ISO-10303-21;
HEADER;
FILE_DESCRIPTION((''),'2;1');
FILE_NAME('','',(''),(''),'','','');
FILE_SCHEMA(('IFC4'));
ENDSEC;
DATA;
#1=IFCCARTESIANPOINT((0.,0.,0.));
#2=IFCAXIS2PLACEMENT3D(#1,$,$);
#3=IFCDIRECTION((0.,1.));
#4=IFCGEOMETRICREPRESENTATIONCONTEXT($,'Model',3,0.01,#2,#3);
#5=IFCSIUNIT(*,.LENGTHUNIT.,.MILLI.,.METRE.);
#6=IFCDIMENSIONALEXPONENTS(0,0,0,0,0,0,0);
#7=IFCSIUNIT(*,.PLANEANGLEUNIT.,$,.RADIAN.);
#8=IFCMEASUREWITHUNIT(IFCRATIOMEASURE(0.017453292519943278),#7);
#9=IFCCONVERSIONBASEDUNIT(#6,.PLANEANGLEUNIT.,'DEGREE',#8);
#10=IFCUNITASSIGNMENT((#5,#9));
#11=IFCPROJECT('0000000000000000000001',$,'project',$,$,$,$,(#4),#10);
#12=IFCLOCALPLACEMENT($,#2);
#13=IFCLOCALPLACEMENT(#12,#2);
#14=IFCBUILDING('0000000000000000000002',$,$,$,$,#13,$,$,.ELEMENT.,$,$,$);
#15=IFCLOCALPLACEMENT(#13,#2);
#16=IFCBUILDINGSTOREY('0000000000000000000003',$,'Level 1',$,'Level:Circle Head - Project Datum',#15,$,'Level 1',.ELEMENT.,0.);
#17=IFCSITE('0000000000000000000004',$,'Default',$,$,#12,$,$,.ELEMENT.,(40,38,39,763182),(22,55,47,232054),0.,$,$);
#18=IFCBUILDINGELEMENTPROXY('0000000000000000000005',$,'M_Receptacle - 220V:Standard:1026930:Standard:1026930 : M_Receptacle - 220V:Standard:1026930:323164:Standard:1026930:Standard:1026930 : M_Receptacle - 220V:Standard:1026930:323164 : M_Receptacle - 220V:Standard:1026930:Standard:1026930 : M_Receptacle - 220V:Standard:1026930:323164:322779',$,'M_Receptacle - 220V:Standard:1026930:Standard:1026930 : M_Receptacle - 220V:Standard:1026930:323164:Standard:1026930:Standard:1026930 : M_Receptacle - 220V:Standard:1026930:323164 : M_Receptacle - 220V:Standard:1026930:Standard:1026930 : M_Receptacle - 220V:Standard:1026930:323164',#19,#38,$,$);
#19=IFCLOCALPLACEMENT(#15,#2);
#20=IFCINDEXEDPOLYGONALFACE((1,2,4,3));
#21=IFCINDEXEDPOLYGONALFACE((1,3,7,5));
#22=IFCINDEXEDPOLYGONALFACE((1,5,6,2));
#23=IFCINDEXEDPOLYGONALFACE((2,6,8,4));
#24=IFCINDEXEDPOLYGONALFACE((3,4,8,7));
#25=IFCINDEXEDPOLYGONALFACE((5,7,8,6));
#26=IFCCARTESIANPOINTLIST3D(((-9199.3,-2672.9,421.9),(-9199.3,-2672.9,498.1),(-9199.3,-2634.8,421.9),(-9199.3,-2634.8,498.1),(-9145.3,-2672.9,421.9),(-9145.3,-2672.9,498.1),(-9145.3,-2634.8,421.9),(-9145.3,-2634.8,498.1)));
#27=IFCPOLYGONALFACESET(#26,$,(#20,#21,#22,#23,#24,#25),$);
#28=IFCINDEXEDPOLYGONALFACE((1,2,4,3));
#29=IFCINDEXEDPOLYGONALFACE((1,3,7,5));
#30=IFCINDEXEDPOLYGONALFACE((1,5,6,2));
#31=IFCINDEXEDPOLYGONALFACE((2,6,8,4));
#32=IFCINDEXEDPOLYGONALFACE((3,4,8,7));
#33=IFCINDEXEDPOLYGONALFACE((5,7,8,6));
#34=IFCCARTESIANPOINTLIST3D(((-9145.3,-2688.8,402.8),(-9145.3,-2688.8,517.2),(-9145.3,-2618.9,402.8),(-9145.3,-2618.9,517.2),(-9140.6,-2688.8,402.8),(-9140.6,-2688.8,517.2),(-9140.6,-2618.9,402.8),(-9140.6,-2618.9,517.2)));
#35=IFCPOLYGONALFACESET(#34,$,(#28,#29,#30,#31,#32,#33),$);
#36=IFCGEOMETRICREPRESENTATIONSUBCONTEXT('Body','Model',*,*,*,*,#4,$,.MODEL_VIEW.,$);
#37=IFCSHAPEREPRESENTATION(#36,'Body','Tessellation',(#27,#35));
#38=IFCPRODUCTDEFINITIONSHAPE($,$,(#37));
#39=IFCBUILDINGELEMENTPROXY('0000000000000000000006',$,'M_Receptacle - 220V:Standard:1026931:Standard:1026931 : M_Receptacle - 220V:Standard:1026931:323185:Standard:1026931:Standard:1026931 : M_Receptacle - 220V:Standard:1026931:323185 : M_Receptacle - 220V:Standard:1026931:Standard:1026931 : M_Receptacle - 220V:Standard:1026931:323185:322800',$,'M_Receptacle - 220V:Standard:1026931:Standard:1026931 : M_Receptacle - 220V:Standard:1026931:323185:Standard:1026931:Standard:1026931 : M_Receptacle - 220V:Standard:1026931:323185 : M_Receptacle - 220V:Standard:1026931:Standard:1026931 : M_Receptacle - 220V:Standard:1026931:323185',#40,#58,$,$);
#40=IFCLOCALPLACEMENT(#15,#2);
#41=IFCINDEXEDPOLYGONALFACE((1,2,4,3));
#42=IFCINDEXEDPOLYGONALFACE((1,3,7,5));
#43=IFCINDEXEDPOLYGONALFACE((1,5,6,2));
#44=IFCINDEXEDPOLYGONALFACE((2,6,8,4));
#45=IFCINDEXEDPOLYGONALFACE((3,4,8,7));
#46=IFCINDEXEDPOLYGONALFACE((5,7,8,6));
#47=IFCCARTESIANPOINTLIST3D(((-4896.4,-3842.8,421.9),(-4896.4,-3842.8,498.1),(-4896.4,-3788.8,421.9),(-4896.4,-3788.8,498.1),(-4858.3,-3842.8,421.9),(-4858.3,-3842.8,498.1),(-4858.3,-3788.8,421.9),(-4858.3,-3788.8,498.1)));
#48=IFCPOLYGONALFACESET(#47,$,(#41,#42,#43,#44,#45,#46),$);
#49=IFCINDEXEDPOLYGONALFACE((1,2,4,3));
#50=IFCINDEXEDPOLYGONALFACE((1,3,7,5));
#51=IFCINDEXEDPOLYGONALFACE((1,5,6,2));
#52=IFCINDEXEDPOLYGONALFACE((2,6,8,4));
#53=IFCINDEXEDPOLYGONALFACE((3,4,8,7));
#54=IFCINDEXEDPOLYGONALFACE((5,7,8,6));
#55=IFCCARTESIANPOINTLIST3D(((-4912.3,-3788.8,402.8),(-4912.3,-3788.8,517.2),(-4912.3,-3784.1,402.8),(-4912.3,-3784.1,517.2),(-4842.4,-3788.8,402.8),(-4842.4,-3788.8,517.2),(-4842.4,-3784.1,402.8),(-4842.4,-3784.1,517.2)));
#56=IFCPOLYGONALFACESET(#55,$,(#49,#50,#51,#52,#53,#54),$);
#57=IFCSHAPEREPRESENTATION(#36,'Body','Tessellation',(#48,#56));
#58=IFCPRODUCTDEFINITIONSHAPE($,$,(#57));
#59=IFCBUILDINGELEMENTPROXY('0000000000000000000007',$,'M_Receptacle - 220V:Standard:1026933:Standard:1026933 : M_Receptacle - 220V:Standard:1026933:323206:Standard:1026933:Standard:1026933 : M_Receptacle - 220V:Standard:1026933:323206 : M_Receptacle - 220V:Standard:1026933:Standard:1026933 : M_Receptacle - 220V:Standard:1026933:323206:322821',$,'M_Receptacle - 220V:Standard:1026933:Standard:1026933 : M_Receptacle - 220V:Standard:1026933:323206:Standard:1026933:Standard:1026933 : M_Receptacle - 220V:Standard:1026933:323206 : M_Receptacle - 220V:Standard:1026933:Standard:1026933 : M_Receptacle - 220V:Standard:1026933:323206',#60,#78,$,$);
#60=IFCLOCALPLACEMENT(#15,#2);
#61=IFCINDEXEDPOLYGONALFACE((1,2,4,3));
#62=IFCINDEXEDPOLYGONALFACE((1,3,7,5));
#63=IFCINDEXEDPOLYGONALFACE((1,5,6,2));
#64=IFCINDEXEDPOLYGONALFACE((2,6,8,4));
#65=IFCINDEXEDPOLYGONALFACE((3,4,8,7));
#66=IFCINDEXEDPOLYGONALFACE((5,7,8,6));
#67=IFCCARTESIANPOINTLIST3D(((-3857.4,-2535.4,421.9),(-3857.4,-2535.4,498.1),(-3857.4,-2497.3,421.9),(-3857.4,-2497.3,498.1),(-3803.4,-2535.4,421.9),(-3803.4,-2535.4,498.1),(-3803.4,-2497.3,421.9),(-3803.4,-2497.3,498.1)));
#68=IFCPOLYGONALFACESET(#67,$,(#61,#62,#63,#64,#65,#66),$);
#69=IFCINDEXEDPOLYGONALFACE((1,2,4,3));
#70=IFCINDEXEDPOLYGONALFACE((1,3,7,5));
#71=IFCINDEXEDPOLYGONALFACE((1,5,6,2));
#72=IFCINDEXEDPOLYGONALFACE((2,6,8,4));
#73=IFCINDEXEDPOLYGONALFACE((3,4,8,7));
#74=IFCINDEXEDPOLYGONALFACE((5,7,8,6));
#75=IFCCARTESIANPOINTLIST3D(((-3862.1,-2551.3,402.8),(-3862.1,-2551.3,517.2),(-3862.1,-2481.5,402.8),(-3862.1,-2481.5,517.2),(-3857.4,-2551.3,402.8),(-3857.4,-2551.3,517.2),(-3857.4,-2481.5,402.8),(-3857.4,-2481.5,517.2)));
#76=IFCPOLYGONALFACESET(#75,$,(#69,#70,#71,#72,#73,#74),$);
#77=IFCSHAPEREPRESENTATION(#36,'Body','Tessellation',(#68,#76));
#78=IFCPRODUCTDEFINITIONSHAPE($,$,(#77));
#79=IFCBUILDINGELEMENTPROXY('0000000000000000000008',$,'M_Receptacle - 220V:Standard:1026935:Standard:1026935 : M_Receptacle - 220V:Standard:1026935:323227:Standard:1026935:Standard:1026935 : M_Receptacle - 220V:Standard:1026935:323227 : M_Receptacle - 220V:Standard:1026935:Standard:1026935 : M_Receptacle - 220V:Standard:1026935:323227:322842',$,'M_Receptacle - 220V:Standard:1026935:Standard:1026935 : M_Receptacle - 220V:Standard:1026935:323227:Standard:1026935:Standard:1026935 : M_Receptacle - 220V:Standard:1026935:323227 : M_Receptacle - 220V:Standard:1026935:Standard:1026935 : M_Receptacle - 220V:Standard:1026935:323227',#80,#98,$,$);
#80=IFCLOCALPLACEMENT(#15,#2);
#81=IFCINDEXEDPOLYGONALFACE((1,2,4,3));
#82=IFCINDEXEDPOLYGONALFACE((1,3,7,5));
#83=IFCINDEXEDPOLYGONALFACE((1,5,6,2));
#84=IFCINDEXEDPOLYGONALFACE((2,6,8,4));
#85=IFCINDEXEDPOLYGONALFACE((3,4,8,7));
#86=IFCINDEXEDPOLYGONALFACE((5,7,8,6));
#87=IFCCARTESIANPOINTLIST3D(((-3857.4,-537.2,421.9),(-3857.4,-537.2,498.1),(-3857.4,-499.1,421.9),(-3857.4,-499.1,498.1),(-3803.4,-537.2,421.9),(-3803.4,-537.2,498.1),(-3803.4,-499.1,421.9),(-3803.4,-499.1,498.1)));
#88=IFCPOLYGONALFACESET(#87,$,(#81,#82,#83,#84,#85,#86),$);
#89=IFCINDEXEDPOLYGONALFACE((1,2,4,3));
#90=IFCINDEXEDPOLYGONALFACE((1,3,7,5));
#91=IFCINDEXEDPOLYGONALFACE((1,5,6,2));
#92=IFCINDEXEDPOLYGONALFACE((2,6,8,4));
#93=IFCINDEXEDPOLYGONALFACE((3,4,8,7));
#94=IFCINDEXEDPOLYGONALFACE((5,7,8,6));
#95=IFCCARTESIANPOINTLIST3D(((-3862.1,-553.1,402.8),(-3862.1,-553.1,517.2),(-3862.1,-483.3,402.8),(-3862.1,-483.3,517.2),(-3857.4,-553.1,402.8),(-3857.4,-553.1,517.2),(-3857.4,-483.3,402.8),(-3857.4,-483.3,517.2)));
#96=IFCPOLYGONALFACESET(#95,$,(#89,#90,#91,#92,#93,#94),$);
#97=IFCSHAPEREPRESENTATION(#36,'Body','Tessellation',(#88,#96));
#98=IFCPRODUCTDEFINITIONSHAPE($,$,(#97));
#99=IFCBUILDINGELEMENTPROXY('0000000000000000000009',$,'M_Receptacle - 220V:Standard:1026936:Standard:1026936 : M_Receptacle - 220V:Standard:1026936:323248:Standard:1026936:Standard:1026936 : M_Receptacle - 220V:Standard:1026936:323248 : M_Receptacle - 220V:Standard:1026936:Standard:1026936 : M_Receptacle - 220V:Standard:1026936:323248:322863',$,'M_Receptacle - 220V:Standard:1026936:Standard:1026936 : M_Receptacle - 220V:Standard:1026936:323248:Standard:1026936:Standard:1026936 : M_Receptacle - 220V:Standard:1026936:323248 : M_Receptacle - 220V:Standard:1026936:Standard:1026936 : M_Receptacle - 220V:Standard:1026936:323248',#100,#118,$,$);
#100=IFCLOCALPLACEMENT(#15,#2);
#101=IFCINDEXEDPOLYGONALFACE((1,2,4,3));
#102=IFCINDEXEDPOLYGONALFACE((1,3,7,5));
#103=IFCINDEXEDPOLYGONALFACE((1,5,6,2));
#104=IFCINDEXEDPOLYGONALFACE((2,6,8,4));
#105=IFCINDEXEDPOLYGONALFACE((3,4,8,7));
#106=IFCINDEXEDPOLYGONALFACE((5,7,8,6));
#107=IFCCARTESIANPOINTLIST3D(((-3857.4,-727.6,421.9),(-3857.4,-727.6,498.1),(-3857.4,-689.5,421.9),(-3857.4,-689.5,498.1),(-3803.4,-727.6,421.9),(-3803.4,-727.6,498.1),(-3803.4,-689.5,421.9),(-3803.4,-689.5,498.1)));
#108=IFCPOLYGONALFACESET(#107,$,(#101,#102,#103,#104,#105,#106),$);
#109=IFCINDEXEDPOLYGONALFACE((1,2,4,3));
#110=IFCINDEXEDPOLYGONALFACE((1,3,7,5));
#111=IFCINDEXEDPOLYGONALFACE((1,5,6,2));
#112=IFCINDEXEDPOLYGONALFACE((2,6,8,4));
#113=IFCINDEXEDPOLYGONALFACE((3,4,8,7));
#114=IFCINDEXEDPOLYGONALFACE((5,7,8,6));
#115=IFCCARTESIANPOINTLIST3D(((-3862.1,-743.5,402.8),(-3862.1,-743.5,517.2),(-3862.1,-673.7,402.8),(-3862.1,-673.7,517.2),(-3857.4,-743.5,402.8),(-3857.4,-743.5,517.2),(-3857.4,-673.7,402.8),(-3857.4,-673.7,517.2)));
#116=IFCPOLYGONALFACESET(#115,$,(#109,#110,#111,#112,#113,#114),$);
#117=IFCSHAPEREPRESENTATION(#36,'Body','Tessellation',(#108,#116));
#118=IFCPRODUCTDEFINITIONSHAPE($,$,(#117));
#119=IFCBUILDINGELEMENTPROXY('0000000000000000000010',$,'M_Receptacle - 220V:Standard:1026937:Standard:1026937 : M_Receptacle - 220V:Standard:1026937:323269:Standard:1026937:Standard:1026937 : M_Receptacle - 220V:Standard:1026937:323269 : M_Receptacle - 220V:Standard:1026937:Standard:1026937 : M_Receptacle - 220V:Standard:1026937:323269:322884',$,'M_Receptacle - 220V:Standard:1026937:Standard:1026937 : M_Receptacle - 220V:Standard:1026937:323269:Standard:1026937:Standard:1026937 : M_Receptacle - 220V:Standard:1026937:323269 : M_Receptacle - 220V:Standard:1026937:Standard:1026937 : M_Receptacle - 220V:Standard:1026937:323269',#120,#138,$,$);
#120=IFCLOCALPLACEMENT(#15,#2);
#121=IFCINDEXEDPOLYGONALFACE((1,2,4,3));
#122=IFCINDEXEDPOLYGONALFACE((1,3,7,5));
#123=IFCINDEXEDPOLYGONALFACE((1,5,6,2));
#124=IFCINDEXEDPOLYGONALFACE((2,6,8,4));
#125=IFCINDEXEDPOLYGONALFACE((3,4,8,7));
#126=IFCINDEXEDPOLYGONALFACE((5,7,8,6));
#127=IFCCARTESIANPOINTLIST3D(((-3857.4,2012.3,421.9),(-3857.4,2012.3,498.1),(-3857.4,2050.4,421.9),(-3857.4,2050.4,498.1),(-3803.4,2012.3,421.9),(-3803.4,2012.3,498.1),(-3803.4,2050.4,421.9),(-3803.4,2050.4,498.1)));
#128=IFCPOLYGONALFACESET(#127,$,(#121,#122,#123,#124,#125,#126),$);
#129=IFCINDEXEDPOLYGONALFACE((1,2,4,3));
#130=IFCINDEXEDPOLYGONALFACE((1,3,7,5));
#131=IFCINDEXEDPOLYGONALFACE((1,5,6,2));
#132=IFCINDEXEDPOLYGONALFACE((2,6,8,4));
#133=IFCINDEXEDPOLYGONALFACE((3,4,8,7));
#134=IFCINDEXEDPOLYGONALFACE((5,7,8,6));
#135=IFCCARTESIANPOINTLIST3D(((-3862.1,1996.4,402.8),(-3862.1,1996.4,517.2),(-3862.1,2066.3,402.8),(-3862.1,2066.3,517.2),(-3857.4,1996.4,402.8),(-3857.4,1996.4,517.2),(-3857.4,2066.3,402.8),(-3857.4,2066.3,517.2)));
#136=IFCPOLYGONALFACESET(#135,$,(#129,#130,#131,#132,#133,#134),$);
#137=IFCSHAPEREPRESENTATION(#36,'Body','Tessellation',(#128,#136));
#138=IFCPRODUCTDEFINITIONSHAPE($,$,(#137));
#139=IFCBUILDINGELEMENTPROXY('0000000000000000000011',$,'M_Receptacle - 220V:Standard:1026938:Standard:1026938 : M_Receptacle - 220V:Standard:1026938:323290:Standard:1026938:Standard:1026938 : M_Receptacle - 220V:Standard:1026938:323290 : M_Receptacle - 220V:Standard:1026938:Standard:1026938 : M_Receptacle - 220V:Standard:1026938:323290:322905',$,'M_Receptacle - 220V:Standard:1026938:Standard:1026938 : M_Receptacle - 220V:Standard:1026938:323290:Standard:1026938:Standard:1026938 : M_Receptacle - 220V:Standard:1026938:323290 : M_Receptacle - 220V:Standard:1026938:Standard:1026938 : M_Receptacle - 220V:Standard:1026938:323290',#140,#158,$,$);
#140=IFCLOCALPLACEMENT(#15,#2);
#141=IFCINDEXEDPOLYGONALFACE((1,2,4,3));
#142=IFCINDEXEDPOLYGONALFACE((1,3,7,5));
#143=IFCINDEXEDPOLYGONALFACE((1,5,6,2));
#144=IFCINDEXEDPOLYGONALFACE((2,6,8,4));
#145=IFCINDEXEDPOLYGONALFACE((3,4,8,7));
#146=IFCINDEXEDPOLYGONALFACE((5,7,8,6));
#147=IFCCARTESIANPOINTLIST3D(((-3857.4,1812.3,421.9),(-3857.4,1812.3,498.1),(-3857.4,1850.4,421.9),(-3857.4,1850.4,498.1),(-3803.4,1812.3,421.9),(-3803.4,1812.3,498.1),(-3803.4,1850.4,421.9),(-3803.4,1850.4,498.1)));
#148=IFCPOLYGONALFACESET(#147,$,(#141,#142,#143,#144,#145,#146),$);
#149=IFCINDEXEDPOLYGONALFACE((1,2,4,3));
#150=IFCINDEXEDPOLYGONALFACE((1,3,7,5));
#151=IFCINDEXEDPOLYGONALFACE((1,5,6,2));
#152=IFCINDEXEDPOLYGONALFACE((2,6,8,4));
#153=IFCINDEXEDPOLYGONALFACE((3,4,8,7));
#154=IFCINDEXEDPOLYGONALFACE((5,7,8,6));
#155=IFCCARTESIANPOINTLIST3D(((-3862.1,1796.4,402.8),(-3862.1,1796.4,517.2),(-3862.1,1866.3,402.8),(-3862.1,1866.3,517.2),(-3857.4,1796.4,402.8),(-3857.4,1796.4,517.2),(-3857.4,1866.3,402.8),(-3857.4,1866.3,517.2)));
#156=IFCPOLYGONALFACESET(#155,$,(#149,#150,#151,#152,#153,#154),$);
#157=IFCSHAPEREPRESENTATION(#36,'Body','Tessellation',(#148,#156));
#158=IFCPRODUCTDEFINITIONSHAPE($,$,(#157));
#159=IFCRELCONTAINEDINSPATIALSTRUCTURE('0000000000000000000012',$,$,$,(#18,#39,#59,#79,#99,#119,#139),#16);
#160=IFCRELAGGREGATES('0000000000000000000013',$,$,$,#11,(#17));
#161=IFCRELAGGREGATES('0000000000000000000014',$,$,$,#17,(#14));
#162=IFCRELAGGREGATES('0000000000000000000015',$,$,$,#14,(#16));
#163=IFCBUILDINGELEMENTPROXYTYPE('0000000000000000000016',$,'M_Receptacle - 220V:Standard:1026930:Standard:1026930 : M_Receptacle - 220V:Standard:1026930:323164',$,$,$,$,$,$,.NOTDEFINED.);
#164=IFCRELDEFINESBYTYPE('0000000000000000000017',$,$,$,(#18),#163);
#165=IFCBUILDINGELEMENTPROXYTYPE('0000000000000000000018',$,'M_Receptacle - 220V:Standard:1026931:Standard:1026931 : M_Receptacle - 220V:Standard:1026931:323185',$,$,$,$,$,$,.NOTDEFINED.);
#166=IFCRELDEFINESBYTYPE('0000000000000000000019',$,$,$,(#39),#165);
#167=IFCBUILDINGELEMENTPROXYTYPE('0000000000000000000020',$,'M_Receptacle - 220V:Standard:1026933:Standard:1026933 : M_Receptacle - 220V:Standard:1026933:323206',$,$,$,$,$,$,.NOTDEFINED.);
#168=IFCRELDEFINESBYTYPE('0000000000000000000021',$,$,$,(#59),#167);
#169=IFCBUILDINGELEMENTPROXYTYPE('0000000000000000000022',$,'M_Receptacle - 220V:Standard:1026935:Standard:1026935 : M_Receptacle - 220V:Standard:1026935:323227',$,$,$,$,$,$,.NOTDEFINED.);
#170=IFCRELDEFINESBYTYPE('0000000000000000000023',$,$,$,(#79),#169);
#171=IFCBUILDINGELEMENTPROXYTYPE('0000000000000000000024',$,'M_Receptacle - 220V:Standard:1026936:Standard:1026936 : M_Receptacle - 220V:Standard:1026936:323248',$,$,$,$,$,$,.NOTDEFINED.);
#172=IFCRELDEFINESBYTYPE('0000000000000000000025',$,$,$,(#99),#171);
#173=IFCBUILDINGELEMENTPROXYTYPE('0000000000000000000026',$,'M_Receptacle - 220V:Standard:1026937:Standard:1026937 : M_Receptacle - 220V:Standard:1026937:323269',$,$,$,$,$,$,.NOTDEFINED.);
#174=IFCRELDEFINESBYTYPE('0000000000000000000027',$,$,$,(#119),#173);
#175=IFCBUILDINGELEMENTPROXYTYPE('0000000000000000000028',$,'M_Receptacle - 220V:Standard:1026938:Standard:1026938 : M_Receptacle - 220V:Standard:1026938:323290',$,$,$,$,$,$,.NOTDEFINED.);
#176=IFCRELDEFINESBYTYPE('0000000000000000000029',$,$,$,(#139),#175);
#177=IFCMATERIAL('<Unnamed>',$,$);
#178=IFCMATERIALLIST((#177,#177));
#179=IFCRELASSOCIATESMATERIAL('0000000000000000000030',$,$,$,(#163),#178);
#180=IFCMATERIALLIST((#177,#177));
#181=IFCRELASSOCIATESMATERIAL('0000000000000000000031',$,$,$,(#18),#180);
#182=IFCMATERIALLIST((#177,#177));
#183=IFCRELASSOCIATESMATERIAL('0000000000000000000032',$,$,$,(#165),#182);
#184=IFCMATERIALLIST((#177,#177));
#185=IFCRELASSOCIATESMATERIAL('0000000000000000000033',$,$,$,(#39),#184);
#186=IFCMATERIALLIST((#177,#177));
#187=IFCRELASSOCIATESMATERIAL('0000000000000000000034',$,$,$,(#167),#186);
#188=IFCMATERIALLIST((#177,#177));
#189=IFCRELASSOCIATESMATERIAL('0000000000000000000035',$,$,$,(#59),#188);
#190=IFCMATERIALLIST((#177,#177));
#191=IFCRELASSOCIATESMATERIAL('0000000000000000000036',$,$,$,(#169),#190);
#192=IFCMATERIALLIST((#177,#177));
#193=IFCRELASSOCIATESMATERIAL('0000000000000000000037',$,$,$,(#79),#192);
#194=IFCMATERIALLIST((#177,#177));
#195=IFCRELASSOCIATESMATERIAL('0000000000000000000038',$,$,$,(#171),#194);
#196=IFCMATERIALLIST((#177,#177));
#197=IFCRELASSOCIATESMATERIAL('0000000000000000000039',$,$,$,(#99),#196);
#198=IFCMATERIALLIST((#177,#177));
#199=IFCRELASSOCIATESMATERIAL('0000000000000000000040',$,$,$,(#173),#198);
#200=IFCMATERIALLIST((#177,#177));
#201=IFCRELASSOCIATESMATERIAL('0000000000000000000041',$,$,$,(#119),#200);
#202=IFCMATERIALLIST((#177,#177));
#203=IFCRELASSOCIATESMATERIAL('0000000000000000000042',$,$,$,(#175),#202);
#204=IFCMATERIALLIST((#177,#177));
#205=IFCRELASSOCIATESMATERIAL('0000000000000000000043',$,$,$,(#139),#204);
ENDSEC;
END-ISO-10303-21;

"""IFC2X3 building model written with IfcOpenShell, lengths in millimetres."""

from ifc_helpers import new_model, entity, si_unit, converted_unit, direction, frame, frame_2d, origin, origin_2d_with_axis, place, context, subcontext, project, spatial, rectangle, extrude, source, transform, mapped, material, material_list, type_object, type_shapes, element, save


model = new_model("IFC2X3")

# Units and contexts
model_context = context("Model", 3, precision=0.01, world=origin(), true_north=direction((0.0, 1.0)))
body_context = subcontext(model_context, "Body", "Model", "MODEL_VIEW")
ifc_project = project(units=[si_unit("LENGTHUNIT", "METRE", prefix="MILLI"), converted_unit("PLANEANGLEUNIT", "DEGREE", entity("IfcRatioMeasure", 0.017453292519943278), si_unit("PLANEANGLEUNIT", "RADIAN"), dimensions=[0, 0, 0, 0, 0, 0, 0])], contexts=[model_context])

# Site, building, storey
site_placement = place(None, origin())
site = spatial("IfcSite", under=ifc_project, at=site_placement, Name="Default", CompositionType="ELEMENT", RefLatitude=(40, 38, 39, 763182), RefLongitude=(22, 55, 47, 232054), RefElevation=0.0)
building_placement = place(site_placement, origin())
building = spatial("IfcBuilding", under=site, at=building_placement, CompositionType="ELEMENT")
storey_placement = place(building_placement, origin())
storey = spatial("IfcBuildingStorey", under=building, at=storey_placement, Name="Level 1", ObjectType="Level:Circle Head - Project Datum", LongName="Level 1", CompositionType="ELEMENT", Elevation=0.0)

# Shared definitions
ifc_material_1 = material(Name="<Unnamed>")

# Building element proxies
ifc_material_list_1 = material_list([ifc_material_1, ifc_material_1])
ifc_material_list_2 = material_list([ifc_material_1, ifc_material_1])
building_element_proxy_type_1 = type_object("IfcBuildingElementProxyType", Name="M_Receptacle - 220V:Standard:1026930:Standard:1026930 : M_Receptacle - 220V:Standard:1026930:323164", PredefinedType="NOTDEFINED", material=ifc_material_list_2)
shared_shape_1 = source(origin(), body_context, "Body", "SweptSolid", [
    extrude(rectangle(XDim=38.1, YDim=54.0, at=frame_2d((0.0, 0.0), x_axis=(1.0, 0.0))), frame((-9172.3, -2653.8, 421.9), z_axis=(0.0, 0.0, 1.0), x_axis=(0.0, -1.0, 0.0)), (0.0, 0.0, 1.0), 76.2),
    extrude(rectangle(XDim=69.8, YDim=4.8, at=frame_2d((0.0, 0.0), x_axis=(1.0, 0.0))), frame((-9143.0, -2653.8, 402.8), z_axis=(0.0, 0.0, 1.0), x_axis=(0.0, -1.0, 0.0)), (0.0, 0.0, 1.0), 114.3),
])
type_shapes(building_element_proxy_type_1, [shared_shape_1])
proxy_1_placement = place(storey_placement, origin())
element("IfcBuildingElementProxy", 1, at=proxy_1_placement, inside=storey, type_object=building_element_proxy_type_1, material=ifc_material_list_1, Name="M_Receptacle - 220V:Standard:1026930:Standard:1026930 : M_Receptacle - 220V:Standard:1026930:323164:Standard:1026930:Standard:1026930 : M_Receptacle - 220V:Standard:1026930:323164 : M_Receptacle - 220V:Standard:1026930:Standard:1026930 : M_Receptacle - 220V:Standard:1026930:323164:322779", ObjectType="M_Receptacle - 220V:Standard:1026930:Standard:1026930 : M_Receptacle - 220V:Standard:1026930:323164:Standard:1026930:Standard:1026930 : M_Receptacle - 220V:Standard:1026930:323164 : M_Receptacle - 220V:Standard:1026930:Standard:1026930 : M_Receptacle - 220V:Standard:1026930:323164", context=body_context, shape_type="MappedRepresentation", body=[
    mapped(shared_shape_1, transform((0.0, 0.0, 0.0), scale=1.0)),
])
ifc_material_list_3 = material_list([ifc_material_1, ifc_material_1])
ifc_material_list_4 = material_list([ifc_material_1, ifc_material_1])
building_element_proxy_type_2 = type_object("IfcBuildingElementProxyType", Name="M_Receptacle - 220V:Standard:1026931:Standard:1026931 : M_Receptacle - 220V:Standard:1026931:323185", PredefinedType="NOTDEFINED", material=ifc_material_list_4)
shared_shape_2 = source(origin(), body_context, "Body", "SweptSolid", [
    extrude(rectangle(XDim=38.1, YDim=54.0, at=frame_2d((0.0, 0.0), x_axis=(1.0, 0.0))), frame((-4877.4, -3815.8, 421.9)), (0.0, 0.0, 1.0), 76.2),
    extrude(rectangle(XDim=69.8, YDim=4.8, at=frame_2d((0.0, 0.0), x_axis=(1.0, 0.0))), frame((-4877.4, -3786.5, 402.8)), (0.0, 0.0, 1.0), 114.3),
])
type_shapes(building_element_proxy_type_2, [shared_shape_2])
proxy_2_placement = place(storey_placement, origin())
element("IfcBuildingElementProxy", 2, at=proxy_2_placement, inside=storey, type_object=building_element_proxy_type_2, material=ifc_material_list_3, Name="M_Receptacle - 220V:Standard:1026931:Standard:1026931 : M_Receptacle - 220V:Standard:1026931:323185:Standard:1026931:Standard:1026931 : M_Receptacle - 220V:Standard:1026931:323185 : M_Receptacle - 220V:Standard:1026931:Standard:1026931 : M_Receptacle - 220V:Standard:1026931:323185:322800", ObjectType="M_Receptacle - 220V:Standard:1026931:Standard:1026931 : M_Receptacle - 220V:Standard:1026931:323185:Standard:1026931:Standard:1026931 : M_Receptacle - 220V:Standard:1026931:323185 : M_Receptacle - 220V:Standard:1026931:Standard:1026931 : M_Receptacle - 220V:Standard:1026931:323185", context=body_context, shape_type="MappedRepresentation", body=[
    mapped(shared_shape_2, transform((0.0, 0.0, 0.0), scale=1.0)),
])
ifc_material_list_5 = material_list([ifc_material_1, ifc_material_1])
ifc_material_list_6 = material_list([ifc_material_1, ifc_material_1])
building_element_proxy_type_3 = type_object("IfcBuildingElementProxyType", Name="M_Receptacle - 220V:Standard:1026933:Standard:1026933 : M_Receptacle - 220V:Standard:1026933:323206", PredefinedType="NOTDEFINED", material=ifc_material_list_6)
shared_shape_3 = source(origin(), body_context, "Body", "SweptSolid", [
    extrude(rectangle(XDim=38.1, YDim=54.0, at=frame_2d((0.0, 0.0), x_axis=(1.0, 0.0))), frame((-3830.4, -2516.4, 421.9), z_axis=(0.0, 0.0, 1.0), x_axis=(0.0, 1.0, 0.0)), (0.0, 0.0, 1.0), 76.2),
    extrude(rectangle(XDim=69.8, YDim=4.8, at=frame_2d((0.0, 0.0), x_axis=(1.0, 0.0))), frame((-3859.7, -2516.4, 402.8), z_axis=(0.0, 0.0, 1.0), x_axis=(0.0, 1.0, 0.0)), (0.0, 0.0, 1.0), 114.3),
])
type_shapes(building_element_proxy_type_3, [shared_shape_3])
proxy_3_placement = place(storey_placement, origin())
element("IfcBuildingElementProxy", 3, at=proxy_3_placement, inside=storey, type_object=building_element_proxy_type_3, material=ifc_material_list_5, Name="M_Receptacle - 220V:Standard:1026933:Standard:1026933 : M_Receptacle - 220V:Standard:1026933:323206:Standard:1026933:Standard:1026933 : M_Receptacle - 220V:Standard:1026933:323206 : M_Receptacle - 220V:Standard:1026933:Standard:1026933 : M_Receptacle - 220V:Standard:1026933:323206:322821", ObjectType="M_Receptacle - 220V:Standard:1026933:Standard:1026933 : M_Receptacle - 220V:Standard:1026933:323206:Standard:1026933:Standard:1026933 : M_Receptacle - 220V:Standard:1026933:323206 : M_Receptacle - 220V:Standard:1026933:Standard:1026933 : M_Receptacle - 220V:Standard:1026933:323206", context=body_context, shape_type="MappedRepresentation", body=[
    mapped(shared_shape_3, transform((0.0, 0.0, 0.0), scale=1.0)),
])
ifc_material_list_7 = material_list([ifc_material_1, ifc_material_1])
ifc_material_list_8 = material_list([ifc_material_1, ifc_material_1])
building_element_proxy_type_4 = type_object("IfcBuildingElementProxyType", Name="M_Receptacle - 220V:Standard:1026935:Standard:1026935 : M_Receptacle - 220V:Standard:1026935:323227", PredefinedType="NOTDEFINED", material=ifc_material_list_8)
shared_shape_4 = source(origin(), body_context, "Body", "SweptSolid", [
    extrude(rectangle(XDim=38.1, YDim=54.0, at=frame_2d((0.0, 0.0), x_axis=(1.0, 0.0))), frame((-3830.4, -518.2, 421.9), z_axis=(0.0, 0.0, 1.0), x_axis=(0.0, 1.0, 0.0)), (0.0, 0.0, 1.0), 76.2),
    extrude(rectangle(XDim=69.8, YDim=4.8, at=frame_2d((0.0, 0.0), x_axis=(1.0, 0.0))), frame((-3859.7, -518.2, 402.8), z_axis=(0.0, 0.0, 1.0), x_axis=(0.0, 1.0, 0.0)), (0.0, 0.0, 1.0), 114.3),
])
type_shapes(building_element_proxy_type_4, [shared_shape_4])
proxy_4_placement = place(storey_placement, origin())
element("IfcBuildingElementProxy", 4, at=proxy_4_placement, inside=storey, type_object=building_element_proxy_type_4, material=ifc_material_list_7, Name="M_Receptacle - 220V:Standard:1026935:Standard:1026935 : M_Receptacle - 220V:Standard:1026935:323227:Standard:1026935:Standard:1026935 : M_Receptacle - 220V:Standard:1026935:323227 : M_Receptacle - 220V:Standard:1026935:Standard:1026935 : M_Receptacle - 220V:Standard:1026935:323227:322842", ObjectType="M_Receptacle - 220V:Standard:1026935:Standard:1026935 : M_Receptacle - 220V:Standard:1026935:323227:Standard:1026935:Standard:1026935 : M_Receptacle - 220V:Standard:1026935:323227 : M_Receptacle - 220V:Standard:1026935:Standard:1026935 : M_Receptacle - 220V:Standard:1026935:323227", context=body_context, shape_type="MappedRepresentation", body=[
    mapped(shared_shape_4, transform((0.0, 0.0, 0.0), scale=1.0)),
])
ifc_material_list_9 = material_list([ifc_material_1, ifc_material_1])
ifc_material_list_10 = material_list([ifc_material_1, ifc_material_1])
building_element_proxy_type_5 = type_object("IfcBuildingElementProxyType", Name="M_Receptacle - 220V:Standard:1026936:Standard:1026936 : M_Receptacle - 220V:Standard:1026936:323248", PredefinedType="NOTDEFINED", material=ifc_material_list_10)
shared_shape_5 = source(origin(), body_context, "Body", "SweptSolid", [
    extrude(rectangle(XDim=38.1, YDim=54.0, at=frame_2d((0.0, 0.0), x_axis=(1.0, 0.0))), frame((-3830.4, -708.6, 421.9), z_axis=(0.0, 0.0, 1.0), x_axis=(0.0, 1.0, 0.0)), (0.0, 0.0, 1.0), 76.2),
    extrude(rectangle(XDim=69.8, YDim=4.8, at=origin_2d_with_axis()), frame((-3859.7, -708.6, 402.8), z_axis=(0.0, 0.0, 1.0), x_axis=(0.0, 1.0, 0.0)), (0.0, 0.0, 1.0), 114.3),
])
type_shapes(building_element_proxy_type_5, [shared_shape_5])
proxy_5_placement = place(storey_placement, origin())
element("IfcBuildingElementProxy", 5, at=proxy_5_placement, inside=storey, type_object=building_element_proxy_type_5, material=ifc_material_list_9, Name="M_Receptacle - 220V:Standard:1026936:Standard:1026936 : M_Receptacle - 220V:Standard:1026936:323248:Standard:1026936:Standard:1026936 : M_Receptacle - 220V:Standard:1026936:323248 : M_Receptacle - 220V:Standard:1026936:Standard:1026936 : M_Receptacle - 220V:Standard:1026936:323248:322863", ObjectType="M_Receptacle - 220V:Standard:1026936:Standard:1026936 : M_Receptacle - 220V:Standard:1026936:323248:Standard:1026936:Standard:1026936 : M_Receptacle - 220V:Standard:1026936:323248 : M_Receptacle - 220V:Standard:1026936:Standard:1026936 : M_Receptacle - 220V:Standard:1026936:323248", context=body_context, shape_type="MappedRepresentation", body=[
    mapped(shared_shape_5, transform((0.0, 0.0, 0.0), scale=1.0)),
])
ifc_material_list_11 = material_list([ifc_material_1, ifc_material_1])
ifc_material_list_12 = material_list([ifc_material_1, ifc_material_1])
building_element_proxy_type_6 = type_object("IfcBuildingElementProxyType", Name="M_Receptacle - 220V:Standard:1026937:Standard:1026937 : M_Receptacle - 220V:Standard:1026937:323269", PredefinedType="NOTDEFINED", material=ifc_material_list_12)
shared_shape_6 = source(origin(), body_context, "Body", "SweptSolid", [
    extrude(rectangle(XDim=38.1, YDim=54.0, at=frame_2d((0.0, 0.0), x_axis=(1.0, 0.0))), frame((-3830.4, 2031.4, 421.9), z_axis=(0.0, 0.0, 1.0), x_axis=(0.0, 1.0, 0.0)), (0.0, 0.0, 1.0), 76.2),
    extrude(rectangle(XDim=69.8, YDim=4.8, at=frame_2d((0.0, 0.0), x_axis=(1.0, 0.0))), frame((-3859.7, 2031.4, 402.8), z_axis=(0.0, 0.0, 1.0), x_axis=(0.0, 1.0, 0.0)), (0.0, 0.0, 1.0), 114.3),
])
type_shapes(building_element_proxy_type_6, [shared_shape_6])
proxy_6_placement = place(storey_placement, origin())
element("IfcBuildingElementProxy", 6, at=proxy_6_placement, inside=storey, type_object=building_element_proxy_type_6, material=ifc_material_list_11, Name="M_Receptacle - 220V:Standard:1026937:Standard:1026937 : M_Receptacle - 220V:Standard:1026937:323269:Standard:1026937:Standard:1026937 : M_Receptacle - 220V:Standard:1026937:323269 : M_Receptacle - 220V:Standard:1026937:Standard:1026937 : M_Receptacle - 220V:Standard:1026937:323269:322884", ObjectType="M_Receptacle - 220V:Standard:1026937:Standard:1026937 : M_Receptacle - 220V:Standard:1026937:323269:Standard:1026937:Standard:1026937 : M_Receptacle - 220V:Standard:1026937:323269 : M_Receptacle - 220V:Standard:1026937:Standard:1026937 : M_Receptacle - 220V:Standard:1026937:323269", context=body_context, shape_type="MappedRepresentation", body=[
    mapped(shared_shape_6, transform((0.0, 0.0, 0.0), scale=1.0)),
])
ifc_material_list_13 = material_list([ifc_material_1, ifc_material_1])
ifc_material_list_14 = material_list([ifc_material_1, ifc_material_1])
building_element_proxy_type_7 = type_object("IfcBuildingElementProxyType", Name="M_Receptacle - 220V:Standard:1026938:Standard:1026938 : M_Receptacle - 220V:Standard:1026938:323290", PredefinedType="NOTDEFINED", material=ifc_material_list_14)
shared_shape_7 = source(origin(), body_context, "Body", "SweptSolid", [
    extrude(rectangle(XDim=38.1, YDim=54.0, at=frame_2d((0.0, 0.0), x_axis=(1.0, 0.0))), frame((-3830.4, 1831.4, 421.9), z_axis=(0.0, 0.0, 1.0), x_axis=(0.0, 1.0, 0.0)), (0.0, 0.0, 1.0), 76.2),
    extrude(rectangle(XDim=69.8, YDim=4.8, at=frame_2d((0.0, 0.0), x_axis=(1.0, 0.0))), frame((-3859.7, 1831.4, 402.8), z_axis=(0.0, 0.0, 1.0), x_axis=(0.0, 1.0, 0.0)), (0.0, 0.0, 1.0), 114.3),
])
type_shapes(building_element_proxy_type_7, [shared_shape_7])
proxy_7_placement = place(storey_placement, origin())
element("IfcBuildingElementProxy", 7, at=proxy_7_placement, inside=storey, type_object=building_element_proxy_type_7, material=ifc_material_list_13, Name="M_Receptacle - 220V:Standard:1026938:Standard:1026938 : M_Receptacle - 220V:Standard:1026938:323290:Standard:1026938:Standard:1026938 : M_Receptacle - 220V:Standard:1026938:323290 : M_Receptacle - 220V:Standard:1026938:Standard:1026938 : M_Receptacle - 220V:Standard:1026938:323290:322905", ObjectType="M_Receptacle - 220V:Standard:1026938:Standard:1026938 : M_Receptacle - 220V:Standard:1026938:323290:Standard:1026938:Standard:1026938 : M_Receptacle - 220V:Standard:1026938:323290 : M_Receptacle - 220V:Standard:1026938:Standard:1026938 : M_Receptacle - 220V:Standard:1026938:323290", context=body_context, shape_type="MappedRepresentation", body=[
    mapped(shared_shape_7, transform((0.0, 0.0, 0.0), scale=1.0)),
])

save(model, "model.ifc")
